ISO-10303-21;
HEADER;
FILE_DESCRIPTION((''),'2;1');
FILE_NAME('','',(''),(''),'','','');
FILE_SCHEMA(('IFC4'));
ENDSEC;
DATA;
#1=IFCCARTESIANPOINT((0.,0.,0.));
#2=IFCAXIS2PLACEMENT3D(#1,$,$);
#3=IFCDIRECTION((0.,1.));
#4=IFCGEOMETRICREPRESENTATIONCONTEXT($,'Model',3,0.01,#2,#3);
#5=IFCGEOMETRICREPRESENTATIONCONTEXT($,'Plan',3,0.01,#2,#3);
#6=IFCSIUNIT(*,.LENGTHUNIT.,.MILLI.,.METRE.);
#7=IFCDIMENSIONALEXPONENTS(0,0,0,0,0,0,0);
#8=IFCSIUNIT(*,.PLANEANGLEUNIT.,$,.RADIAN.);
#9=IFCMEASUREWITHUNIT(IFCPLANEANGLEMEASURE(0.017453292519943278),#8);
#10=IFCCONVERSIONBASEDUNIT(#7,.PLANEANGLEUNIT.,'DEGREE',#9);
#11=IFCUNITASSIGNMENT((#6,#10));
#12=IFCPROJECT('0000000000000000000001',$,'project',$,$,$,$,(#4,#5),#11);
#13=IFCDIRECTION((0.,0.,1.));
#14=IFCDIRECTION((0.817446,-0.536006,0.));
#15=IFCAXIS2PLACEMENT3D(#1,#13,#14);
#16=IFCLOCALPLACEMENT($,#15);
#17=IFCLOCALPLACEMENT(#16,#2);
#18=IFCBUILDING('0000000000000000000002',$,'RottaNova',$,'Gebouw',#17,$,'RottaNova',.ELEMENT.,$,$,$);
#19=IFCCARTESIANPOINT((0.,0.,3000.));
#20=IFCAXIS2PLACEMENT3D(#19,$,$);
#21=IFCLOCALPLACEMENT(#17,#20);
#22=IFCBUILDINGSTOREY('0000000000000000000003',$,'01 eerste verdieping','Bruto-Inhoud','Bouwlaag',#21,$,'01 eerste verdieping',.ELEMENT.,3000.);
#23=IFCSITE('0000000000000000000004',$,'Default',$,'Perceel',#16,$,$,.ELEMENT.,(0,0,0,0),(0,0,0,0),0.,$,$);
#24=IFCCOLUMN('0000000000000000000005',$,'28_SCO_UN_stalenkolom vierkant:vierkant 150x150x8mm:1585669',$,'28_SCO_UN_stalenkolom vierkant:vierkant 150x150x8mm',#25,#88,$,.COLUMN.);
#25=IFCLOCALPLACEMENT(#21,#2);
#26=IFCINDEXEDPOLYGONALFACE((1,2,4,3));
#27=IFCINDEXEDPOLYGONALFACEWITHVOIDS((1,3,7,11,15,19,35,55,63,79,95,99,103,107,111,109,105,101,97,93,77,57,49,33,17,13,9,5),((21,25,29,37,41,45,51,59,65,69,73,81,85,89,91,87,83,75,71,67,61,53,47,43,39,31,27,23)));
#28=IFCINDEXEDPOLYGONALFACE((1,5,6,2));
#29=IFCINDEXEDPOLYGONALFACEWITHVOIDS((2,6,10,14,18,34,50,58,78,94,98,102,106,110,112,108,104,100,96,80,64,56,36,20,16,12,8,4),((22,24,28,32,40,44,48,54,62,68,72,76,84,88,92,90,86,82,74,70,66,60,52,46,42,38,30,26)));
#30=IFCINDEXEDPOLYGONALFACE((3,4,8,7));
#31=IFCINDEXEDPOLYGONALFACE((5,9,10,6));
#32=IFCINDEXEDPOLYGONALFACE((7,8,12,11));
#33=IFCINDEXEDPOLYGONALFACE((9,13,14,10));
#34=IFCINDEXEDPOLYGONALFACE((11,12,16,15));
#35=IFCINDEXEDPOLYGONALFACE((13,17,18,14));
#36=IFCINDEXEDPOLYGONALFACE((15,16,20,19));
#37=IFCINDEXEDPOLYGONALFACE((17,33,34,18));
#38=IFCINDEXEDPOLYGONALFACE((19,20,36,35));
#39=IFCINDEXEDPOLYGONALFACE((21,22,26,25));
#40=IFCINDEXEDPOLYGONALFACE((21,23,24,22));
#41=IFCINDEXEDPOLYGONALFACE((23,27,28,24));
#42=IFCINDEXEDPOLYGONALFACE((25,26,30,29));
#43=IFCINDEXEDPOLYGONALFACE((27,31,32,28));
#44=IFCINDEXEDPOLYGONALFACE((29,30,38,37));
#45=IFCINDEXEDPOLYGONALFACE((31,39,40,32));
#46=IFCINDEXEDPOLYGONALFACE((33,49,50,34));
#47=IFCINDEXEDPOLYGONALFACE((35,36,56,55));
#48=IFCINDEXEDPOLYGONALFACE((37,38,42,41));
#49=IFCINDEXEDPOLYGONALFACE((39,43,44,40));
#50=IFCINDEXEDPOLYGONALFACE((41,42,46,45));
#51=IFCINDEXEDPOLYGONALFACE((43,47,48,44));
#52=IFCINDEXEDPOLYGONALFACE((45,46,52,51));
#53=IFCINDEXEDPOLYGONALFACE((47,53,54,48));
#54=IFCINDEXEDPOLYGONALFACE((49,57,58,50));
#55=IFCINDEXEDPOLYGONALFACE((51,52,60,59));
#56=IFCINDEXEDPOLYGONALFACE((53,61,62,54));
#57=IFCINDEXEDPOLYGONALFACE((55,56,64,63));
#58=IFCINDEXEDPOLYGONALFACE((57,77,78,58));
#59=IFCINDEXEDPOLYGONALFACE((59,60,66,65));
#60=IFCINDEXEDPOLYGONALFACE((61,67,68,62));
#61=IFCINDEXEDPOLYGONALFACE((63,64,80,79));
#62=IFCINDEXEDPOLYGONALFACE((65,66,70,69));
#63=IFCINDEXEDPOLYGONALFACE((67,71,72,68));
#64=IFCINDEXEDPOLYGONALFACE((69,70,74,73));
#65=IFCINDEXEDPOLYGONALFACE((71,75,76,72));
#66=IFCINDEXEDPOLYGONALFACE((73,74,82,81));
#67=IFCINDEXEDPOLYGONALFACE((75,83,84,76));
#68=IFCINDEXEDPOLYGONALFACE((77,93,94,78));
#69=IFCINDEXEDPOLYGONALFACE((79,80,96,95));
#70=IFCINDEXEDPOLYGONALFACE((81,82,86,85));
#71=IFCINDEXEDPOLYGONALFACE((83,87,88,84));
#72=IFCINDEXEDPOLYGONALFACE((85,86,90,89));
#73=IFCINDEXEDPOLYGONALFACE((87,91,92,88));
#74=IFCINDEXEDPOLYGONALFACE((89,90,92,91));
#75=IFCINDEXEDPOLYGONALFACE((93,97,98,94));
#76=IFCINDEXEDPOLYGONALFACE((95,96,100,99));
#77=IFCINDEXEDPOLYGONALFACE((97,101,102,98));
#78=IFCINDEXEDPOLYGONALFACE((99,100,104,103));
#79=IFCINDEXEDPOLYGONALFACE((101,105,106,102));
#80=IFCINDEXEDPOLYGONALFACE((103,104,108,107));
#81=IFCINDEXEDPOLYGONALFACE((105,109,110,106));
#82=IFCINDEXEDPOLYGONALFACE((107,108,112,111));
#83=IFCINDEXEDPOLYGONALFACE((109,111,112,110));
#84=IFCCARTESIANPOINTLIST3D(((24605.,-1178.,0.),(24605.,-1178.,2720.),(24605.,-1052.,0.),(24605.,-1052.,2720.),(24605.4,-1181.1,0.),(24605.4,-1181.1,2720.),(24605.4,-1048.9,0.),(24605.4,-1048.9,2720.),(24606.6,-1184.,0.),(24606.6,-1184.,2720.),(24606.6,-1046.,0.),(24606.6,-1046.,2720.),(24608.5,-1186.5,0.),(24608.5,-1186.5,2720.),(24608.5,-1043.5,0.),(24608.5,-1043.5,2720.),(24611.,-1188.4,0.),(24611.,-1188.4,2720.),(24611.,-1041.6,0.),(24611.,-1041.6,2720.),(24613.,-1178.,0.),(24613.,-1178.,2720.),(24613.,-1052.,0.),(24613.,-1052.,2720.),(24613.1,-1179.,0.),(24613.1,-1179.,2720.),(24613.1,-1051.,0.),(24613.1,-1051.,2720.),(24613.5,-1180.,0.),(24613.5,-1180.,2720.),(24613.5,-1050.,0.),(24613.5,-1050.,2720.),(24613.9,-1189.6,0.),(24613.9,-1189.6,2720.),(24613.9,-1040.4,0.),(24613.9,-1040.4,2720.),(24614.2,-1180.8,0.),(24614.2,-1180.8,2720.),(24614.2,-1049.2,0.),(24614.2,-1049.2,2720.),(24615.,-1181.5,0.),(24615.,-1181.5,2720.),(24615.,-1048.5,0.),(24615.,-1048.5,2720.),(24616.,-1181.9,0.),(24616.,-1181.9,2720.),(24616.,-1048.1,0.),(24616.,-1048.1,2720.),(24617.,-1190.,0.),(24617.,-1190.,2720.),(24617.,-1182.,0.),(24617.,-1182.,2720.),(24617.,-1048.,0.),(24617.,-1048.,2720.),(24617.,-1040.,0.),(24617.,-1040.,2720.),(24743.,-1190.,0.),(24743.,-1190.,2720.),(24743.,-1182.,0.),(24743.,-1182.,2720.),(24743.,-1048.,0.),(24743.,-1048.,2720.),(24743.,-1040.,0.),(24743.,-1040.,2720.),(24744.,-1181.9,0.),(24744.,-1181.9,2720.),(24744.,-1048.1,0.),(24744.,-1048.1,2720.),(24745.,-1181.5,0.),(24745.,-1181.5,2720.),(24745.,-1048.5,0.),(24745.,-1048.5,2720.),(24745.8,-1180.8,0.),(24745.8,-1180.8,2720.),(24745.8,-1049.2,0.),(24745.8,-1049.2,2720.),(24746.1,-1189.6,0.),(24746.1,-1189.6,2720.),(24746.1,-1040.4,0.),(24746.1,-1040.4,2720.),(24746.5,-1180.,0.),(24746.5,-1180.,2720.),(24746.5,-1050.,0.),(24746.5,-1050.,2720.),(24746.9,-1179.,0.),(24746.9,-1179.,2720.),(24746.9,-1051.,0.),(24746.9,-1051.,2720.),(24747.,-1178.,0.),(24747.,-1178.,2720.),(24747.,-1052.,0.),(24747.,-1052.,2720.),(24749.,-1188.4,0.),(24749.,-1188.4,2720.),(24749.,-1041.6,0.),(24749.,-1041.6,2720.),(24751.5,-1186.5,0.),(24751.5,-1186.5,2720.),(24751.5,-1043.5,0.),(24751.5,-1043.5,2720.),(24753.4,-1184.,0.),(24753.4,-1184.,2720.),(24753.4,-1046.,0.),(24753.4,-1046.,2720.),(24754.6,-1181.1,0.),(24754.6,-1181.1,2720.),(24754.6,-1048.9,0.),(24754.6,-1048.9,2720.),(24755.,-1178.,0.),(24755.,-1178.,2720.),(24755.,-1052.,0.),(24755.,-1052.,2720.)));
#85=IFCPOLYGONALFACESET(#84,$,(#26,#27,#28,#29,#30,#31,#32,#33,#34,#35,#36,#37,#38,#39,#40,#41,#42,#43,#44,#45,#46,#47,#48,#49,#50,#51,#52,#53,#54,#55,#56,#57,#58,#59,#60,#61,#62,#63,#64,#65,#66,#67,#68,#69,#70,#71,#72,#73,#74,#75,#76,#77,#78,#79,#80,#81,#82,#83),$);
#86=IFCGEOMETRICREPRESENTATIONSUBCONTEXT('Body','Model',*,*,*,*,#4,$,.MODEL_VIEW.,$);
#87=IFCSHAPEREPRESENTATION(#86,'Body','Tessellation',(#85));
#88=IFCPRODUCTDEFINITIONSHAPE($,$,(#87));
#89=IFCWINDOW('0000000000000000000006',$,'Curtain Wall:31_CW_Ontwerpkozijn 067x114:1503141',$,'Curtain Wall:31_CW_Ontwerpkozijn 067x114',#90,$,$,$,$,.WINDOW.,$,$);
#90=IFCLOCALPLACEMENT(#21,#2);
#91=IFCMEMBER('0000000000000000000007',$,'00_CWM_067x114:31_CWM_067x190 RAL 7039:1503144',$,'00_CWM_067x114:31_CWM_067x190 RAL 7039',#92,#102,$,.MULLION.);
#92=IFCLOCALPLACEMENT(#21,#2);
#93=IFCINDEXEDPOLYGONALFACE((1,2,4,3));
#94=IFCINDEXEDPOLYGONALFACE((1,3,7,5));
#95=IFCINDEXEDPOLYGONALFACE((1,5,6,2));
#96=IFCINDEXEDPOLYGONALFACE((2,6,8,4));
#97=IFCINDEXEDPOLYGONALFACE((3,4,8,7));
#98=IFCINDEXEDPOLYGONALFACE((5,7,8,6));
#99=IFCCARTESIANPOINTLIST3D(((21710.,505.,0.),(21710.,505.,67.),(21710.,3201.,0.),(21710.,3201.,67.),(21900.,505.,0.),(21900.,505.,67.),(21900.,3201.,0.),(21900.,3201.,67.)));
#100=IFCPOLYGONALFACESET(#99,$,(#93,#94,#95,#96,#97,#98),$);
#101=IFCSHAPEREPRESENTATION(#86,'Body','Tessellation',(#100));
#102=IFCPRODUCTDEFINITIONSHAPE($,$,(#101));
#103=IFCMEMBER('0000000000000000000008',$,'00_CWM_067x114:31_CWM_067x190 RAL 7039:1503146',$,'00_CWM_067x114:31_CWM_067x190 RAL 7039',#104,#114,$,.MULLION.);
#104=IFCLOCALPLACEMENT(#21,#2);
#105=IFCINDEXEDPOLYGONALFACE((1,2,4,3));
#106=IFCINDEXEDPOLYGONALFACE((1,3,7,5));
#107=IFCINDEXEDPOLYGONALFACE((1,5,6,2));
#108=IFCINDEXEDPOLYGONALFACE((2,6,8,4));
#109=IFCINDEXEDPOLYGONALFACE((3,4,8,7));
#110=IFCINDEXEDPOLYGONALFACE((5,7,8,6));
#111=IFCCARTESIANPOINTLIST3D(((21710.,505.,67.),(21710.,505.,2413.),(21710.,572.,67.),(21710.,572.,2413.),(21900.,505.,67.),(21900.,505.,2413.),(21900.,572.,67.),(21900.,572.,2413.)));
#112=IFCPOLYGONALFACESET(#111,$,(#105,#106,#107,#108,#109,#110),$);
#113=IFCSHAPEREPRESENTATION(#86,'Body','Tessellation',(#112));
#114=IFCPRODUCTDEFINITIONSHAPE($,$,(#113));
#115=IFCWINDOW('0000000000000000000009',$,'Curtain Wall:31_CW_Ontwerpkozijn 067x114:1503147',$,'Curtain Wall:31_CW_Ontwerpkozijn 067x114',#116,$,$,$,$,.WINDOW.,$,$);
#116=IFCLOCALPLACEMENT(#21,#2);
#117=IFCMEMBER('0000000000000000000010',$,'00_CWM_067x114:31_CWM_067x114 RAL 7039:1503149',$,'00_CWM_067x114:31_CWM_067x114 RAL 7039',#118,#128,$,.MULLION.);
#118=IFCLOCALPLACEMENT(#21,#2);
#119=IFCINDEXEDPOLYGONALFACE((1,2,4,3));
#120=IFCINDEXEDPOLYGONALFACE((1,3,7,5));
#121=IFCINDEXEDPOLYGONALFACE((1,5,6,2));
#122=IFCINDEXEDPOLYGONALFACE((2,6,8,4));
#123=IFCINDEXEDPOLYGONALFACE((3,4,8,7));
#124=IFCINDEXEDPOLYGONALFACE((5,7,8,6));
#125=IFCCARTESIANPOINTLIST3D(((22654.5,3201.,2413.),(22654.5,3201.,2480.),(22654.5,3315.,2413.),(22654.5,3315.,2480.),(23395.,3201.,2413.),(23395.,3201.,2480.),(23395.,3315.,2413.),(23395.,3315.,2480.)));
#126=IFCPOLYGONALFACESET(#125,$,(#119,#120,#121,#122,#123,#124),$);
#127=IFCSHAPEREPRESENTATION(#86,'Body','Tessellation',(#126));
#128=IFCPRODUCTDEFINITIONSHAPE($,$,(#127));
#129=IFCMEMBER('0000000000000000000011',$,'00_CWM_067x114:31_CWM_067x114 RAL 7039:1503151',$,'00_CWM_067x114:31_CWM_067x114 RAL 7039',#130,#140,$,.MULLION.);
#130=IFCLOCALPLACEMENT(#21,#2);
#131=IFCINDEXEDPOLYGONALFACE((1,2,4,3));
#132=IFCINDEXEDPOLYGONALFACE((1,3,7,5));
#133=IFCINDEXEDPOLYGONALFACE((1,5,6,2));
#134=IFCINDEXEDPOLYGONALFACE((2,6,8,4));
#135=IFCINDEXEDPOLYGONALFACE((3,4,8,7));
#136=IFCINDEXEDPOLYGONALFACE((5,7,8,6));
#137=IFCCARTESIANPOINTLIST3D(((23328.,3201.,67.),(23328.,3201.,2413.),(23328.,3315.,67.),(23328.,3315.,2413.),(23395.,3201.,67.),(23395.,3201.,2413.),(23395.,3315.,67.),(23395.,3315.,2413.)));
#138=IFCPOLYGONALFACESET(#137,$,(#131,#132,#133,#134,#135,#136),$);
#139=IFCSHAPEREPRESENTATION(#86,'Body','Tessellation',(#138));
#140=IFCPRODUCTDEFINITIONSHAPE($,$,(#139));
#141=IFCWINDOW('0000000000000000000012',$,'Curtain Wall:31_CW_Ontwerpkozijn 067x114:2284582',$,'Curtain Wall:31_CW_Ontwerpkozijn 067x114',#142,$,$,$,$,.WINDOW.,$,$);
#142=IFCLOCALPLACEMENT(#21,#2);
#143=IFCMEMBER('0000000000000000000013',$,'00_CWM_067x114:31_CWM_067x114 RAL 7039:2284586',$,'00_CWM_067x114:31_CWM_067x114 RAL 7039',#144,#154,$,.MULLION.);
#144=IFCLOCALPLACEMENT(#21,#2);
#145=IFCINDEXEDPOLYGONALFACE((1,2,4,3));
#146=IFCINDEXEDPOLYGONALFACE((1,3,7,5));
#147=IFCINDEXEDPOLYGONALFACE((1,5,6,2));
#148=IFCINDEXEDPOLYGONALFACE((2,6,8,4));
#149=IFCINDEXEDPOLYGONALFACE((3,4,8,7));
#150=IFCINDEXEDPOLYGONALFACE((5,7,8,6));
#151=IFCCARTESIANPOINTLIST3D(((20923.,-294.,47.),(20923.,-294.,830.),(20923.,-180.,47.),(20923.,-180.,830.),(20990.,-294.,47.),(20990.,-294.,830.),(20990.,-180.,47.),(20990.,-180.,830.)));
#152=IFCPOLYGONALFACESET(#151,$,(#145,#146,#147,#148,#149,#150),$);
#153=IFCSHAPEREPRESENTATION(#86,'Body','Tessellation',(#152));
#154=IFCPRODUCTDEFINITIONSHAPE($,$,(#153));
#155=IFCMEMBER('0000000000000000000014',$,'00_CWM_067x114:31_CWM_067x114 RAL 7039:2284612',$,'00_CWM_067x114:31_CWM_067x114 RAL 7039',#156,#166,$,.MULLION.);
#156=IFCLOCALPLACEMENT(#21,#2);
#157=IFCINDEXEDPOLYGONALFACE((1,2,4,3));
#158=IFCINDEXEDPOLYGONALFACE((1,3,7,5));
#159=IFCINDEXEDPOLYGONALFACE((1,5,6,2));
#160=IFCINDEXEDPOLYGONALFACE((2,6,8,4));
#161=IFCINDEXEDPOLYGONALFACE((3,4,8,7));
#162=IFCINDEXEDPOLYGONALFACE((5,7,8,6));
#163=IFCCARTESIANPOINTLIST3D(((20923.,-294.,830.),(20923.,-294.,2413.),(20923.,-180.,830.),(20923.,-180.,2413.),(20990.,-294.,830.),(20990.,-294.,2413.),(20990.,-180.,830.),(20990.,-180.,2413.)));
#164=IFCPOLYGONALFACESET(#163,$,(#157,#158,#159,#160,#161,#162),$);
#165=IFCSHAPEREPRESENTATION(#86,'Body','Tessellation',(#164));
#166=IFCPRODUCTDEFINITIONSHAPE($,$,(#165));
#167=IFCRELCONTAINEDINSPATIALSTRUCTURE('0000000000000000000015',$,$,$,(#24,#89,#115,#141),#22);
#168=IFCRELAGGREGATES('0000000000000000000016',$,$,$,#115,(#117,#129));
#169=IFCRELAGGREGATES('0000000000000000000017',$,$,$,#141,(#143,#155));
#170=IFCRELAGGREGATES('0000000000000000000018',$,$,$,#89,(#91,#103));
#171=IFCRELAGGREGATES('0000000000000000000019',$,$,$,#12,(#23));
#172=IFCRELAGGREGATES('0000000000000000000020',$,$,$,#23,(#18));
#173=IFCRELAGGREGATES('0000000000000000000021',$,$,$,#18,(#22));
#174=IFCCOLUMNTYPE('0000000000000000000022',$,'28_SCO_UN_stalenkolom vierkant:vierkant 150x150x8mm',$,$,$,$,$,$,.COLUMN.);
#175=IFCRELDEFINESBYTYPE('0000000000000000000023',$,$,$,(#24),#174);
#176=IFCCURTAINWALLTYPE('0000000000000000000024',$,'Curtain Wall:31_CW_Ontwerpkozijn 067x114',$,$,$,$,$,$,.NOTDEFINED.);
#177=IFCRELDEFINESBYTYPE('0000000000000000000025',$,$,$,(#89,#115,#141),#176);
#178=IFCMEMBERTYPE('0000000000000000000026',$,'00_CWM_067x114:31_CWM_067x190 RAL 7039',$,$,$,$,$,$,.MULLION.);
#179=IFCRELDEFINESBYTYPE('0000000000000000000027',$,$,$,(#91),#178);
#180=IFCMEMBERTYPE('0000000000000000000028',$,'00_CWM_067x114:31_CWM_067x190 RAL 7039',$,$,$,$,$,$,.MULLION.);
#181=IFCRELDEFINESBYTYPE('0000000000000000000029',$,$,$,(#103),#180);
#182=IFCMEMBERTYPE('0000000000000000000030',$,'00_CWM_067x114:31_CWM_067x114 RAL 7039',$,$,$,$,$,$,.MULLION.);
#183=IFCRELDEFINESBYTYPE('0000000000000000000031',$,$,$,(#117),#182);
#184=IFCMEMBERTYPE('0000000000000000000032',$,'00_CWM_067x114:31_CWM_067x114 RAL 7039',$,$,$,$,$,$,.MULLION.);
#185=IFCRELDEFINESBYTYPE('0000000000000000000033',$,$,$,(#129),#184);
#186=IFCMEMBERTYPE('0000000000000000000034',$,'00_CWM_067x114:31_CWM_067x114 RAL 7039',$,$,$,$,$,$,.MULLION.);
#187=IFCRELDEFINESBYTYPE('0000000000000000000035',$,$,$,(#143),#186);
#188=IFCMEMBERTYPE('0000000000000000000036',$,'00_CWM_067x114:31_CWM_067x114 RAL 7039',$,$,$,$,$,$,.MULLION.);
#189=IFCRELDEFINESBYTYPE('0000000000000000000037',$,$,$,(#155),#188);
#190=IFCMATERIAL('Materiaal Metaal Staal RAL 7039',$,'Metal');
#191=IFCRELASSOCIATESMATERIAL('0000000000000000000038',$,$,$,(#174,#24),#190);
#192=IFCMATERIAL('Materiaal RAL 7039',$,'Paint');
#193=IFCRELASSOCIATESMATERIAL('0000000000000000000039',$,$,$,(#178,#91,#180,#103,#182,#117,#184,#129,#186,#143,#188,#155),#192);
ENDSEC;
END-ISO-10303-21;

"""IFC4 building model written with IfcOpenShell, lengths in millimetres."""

from ifc_helpers import new_model, entity, si_unit, converted_unit, direction, frame, origin, place, context, subcontext, project, spatial, line, arc, indexed_curve, outline, extrude, source, transform, mapped, material, type_object, type_shapes, element, aggregate, save


model = new_model("IFC4")

# Units and contexts
model_context = context("Model", 3, precision=0.01, world=origin(), true_north=direction((0.0, 1.0)))
plan_context = context("Plan", 3, precision=0.01, world=origin(), true_north=direction((0.0, 1.0)))
body_context = subcontext(model_context, "Body", "Model", "MODEL_VIEW")
ifc_project = project(units=[si_unit("LENGTHUNIT", "METRE", prefix="MILLI"), converted_unit("PLANEANGLEUNIT", "DEGREE", entity("IfcPlaneAngleMeasure", 0.017453292519943278), si_unit("PLANEANGLEUNIT", "RADIAN"), dimensions=[0, 0, 0, 0, 0, 0, 0])], contexts=[model_context, plan_context])

# Site, building, storey
site_placement = place(None, frame((0.0, 0.0, 0.0), z_axis=(0.0, 0.0, 1.0), x_axis=(0.817446, -0.536006, 0.0)))
site = spatial("IfcSite", under=ifc_project, at=site_placement, Name="Default", ObjectType="Perceel", CompositionType="ELEMENT", RefLatitude=(0, 0, 0, 0), RefLongitude=(0, 0, 0, 0), RefElevation=0.0)
building_placement = place(site_placement, origin())
building = spatial("IfcBuilding", under=site, at=building_placement, Name="RottaNova", ObjectType="Gebouw", LongName="RottaNova", CompositionType="ELEMENT")
storey_placement = place(building_placement, frame((0.0, 0.0, 3000.0)))
storey = spatial("IfcBuildingStorey", under=building, at=storey_placement, Name="01 eerste verdieping", Description="Bruto-Inhoud", ObjectType="Bouwlaag", LongName="01 eerste verdieping", CompositionType="ELEMENT", Elevation=3000.0)

# Column
ifc_material_1 = material(Name="Materiaal Metaal Staal RAL 7039", Category="Metal")
column_type = type_object("IfcColumnType", Name="28_SCO_UN_stalenkolom vierkant:vierkant 150x150x8mm", PredefinedType="COLUMN", material=ifc_material_1)
shared_shape_1 = source(origin(), body_context, "Body", "SweptSolid", [
    extrude(outline(indexed_curve([(63.0, -75.0), (71.5, -71.5), (75.0, -63.0), (75.0, 63.0), (71.5, 71.5), (63.0, 75.0), (-63.0, 75.0), (-71.5, 71.5), (-75.0, 63.0), (-75.0, -63.0), (-71.5, -71.5), (-63.0, -75.0)], segments=[arc(1, 2, 3), line(3, 4), arc(4, 5, 6), line(6, 7), arc(7, 8, 9), line(9, 10), arc(10, 11, 12), line(12, 1)], self_intersect=False), holes=[indexed_curve([(-67.0, -63.0), (-67.0, 63.0), (-65.8, 65.8), (-63.0, 67.0), (63.0, 67.0), (65.8, 65.8), (67.0, 63.0), (67.0, -63.0), (65.8, -65.8), (63.0, -67.0), (-63.0, -67.0), (-65.8, -65.8)], segments=[line(1, 2), arc(2, 3, 4), line(4, 5), arc(5, 6, 7), line(7, 8), arc(8, 9, 10), line(10, 11), arc(11, 12, 1)], self_intersect=False)]), frame((0.0, 0.0, 3000.0)), (0.0, 0.0, 1.0), 2720.0),
])
type_shapes(column_type, [shared_shape_1])
column_placement = place(storey_placement, frame((24680.0, -1115.0, -3000.0)))
element("IfcColumn", 1, at=column_placement, inside=storey, type_object=column_type, material=ifc_material_1, Name="28_SCO_UN_stalenkolom vierkant:vierkant 150x150x8mm:1585669", ObjectType="28_SCO_UN_stalenkolom vierkant:vierkant 150x150x8mm", PredefinedType="COLUMN", context=body_context, shape_type="MappedRepresentation", body=[
    mapped(shared_shape_1, transform((0.0, 0.0, 0.0), scale=1.0)),
])

# Windows, members
curtain_wall_type = type_object("IfcCurtainWallType", Name="Curtain Wall:31_CW_Ontwerpkozijn 067x114", PredefinedType="NOTDEFINED")
window_1_placement = place(storey_placement, frame((0.0, 0.0, -3000.0)))
window_1 = element("IfcWindow", 2, at=window_1_placement, inside=storey, type_object=curtain_wall_type, Name="Curtain Wall:31_CW_Ontwerpkozijn 067x114:1503141", ObjectType="Curtain Wall:31_CW_Ontwerpkozijn 067x114", PredefinedType="WINDOW")
ifc_material_2 = material(Name="Materiaal RAL 7039", Category="Paint")
member_type_1 = type_object("IfcMemberType", Name="00_CWM_067x114:31_CWM_067x190 RAL 7039", PredefinedType="MULLION", material=ifc_material_2)
shared_shape_2 = source(origin(), body_context, "Body", "SweptSolid", [
    extrude(outline(indexed_curve([(-33.5, -95.0), (33.5, -95.0), (33.5, 95.0), (-33.5, 95.0), (-33.5, -95.0)], self_intersect=False)), frame((-33.5, 95.0, -2696.0), z_axis=(0.0, 0.0, 1.0), x_axis=(-1.0, 0.0, 0.0)), (0.0, 0.0, 1.0), 2696.0),
])
type_shapes(member_type_1, [shared_shape_2])
member_1_placement = place(window_1_placement, frame((21710.0, 505.0, 3000.0), z_axis=(0.0, -1.0, 0.0), x_axis=(0.0, 0.0, -1.0)))
member_1 = element("IfcMember", 3, at=member_1_placement, type_object=member_type_1, material=ifc_material_2, Name="00_CWM_067x114:31_CWM_067x190 RAL 7039:1503144", ObjectType="00_CWM_067x114:31_CWM_067x190 RAL 7039", PredefinedType="MULLION", context=body_context, shape_type="MappedRepresentation", body=[
    mapped(shared_shape_2, transform((0.0, 0.0, 0.0), scale=1.0)),
])
member_type_2 = type_object("IfcMemberType", Name="00_CWM_067x114:31_CWM_067x190 RAL 7039", PredefinedType="MULLION", material=ifc_material_2)
shared_shape_3 = source(origin(), body_context, "Body", "SweptSolid", [
    extrude(outline(indexed_curve([(-33.5, -95.0), (33.5, -95.0), (33.5, 95.0), (-33.5, 95.0), (-33.5, -95.0)], self_intersect=False)), frame((-33.5, 95.0, -2346.0), z_axis=(0.0, 0.0, 1.0), x_axis=(-1.0, 0.0, 0.0)), (0.0, 0.0, 1.0), 2346.0),
])
type_shapes(member_type_2, [shared_shape_3])
member_2_placement = place(window_1_placement, frame((21710.0, 505.0, 5413.0), z_axis=(0.0, 0.0, 1.0), x_axis=(0.0, -1.0, 0.0)))
member_2 = element("IfcMember", 4, at=member_2_placement, type_object=member_type_2, material=ifc_material_2, Name="00_CWM_067x114:31_CWM_067x190 RAL 7039:1503146", ObjectType="00_CWM_067x114:31_CWM_067x190 RAL 7039", PredefinedType="MULLION", context=body_context, shape_type="MappedRepresentation", body=[
    mapped(shared_shape_3, transform((0.0, 0.0, 0.0), scale=1.0)),
])
window_2_placement = place(storey_placement, frame((0.0, 0.0, -3000.0)))
window_2 = element("IfcWindow", 5, at=window_2_placement, inside=storey, type_object=curtain_wall_type, Name="Curtain Wall:31_CW_Ontwerpkozijn 067x114:1503147", ObjectType="Curtain Wall:31_CW_Ontwerpkozijn 067x114", PredefinedType="WINDOW")
member_type_3 = type_object("IfcMemberType", Name="00_CWM_067x114:31_CWM_067x114 RAL 7039", PredefinedType="MULLION", material=ifc_material_2)
shared_shape_4 = source(origin(), body_context, "Body", "SweptSolid", [
    extrude(outline(indexed_curve([(-33.5, -57.0), (33.5, -57.0), (33.5, 57.0), (-33.5, 57.0), (-33.5, -57.0)], self_intersect=False)), frame((-33.5, 57.0, -740.5), z_axis=(0.0, 0.0, 1.0), x_axis=(-1.0, 0.0, 0.0)), (0.0, 0.0, 1.0), 740.5),
])
type_shapes(member_type_3, [shared_shape_4])
member_3_placement = place(window_2_placement, frame((23395.0, 3315.0, 5480.0), z_axis=(1.0, 0.0, 0.0), x_axis=(0.0, 0.0, 1.0)))
member_3 = element("IfcMember", 6, at=member_3_placement, type_object=member_type_3, material=ifc_material_2, Name="00_CWM_067x114:31_CWM_067x114 RAL 7039:1503149", ObjectType="00_CWM_067x114:31_CWM_067x114 RAL 7039", PredefinedType="MULLION", context=body_context, shape_type="MappedRepresentation", body=[
    mapped(shared_shape_4, transform((0.0, 0.0, 0.0), scale=1.0)),
])
member_type_4 = type_object("IfcMemberType", Name="00_CWM_067x114:31_CWM_067x114 RAL 7039", PredefinedType="MULLION", material=ifc_material_2)
shared_shape_5 = source(origin(), body_context, "Body", "SweptSolid", [
    extrude(outline(indexed_curve([(-33.5, -57.0), (33.5, -57.0), (33.5, 57.0), (-33.5, 57.0), (-33.5, -57.0)], self_intersect=False)), frame((-33.5, 57.0, -2346.0), z_axis=(0.0, 0.0, 1.0), x_axis=(-1.0, 0.0, 0.0)), (0.0, 0.0, 1.0), 2346.0),
])
type_shapes(member_type_4, [shared_shape_5])
member_4_placement = place(window_2_placement, frame((23395.0, 3315.0, 3067.0), z_axis=(0.0, 0.0, -1.0), x_axis=(1.0, 0.0, 0.0)))
member_4 = element("IfcMember", 7, at=member_4_placement, type_object=member_type_4, material=ifc_material_2, Name="00_CWM_067x114:31_CWM_067x114 RAL 7039:1503151", ObjectType="00_CWM_067x114:31_CWM_067x114 RAL 7039", PredefinedType="MULLION", context=body_context, shape_type="MappedRepresentation", body=[
    mapped(shared_shape_5, transform((0.0, 0.0, 0.0), scale=1.0)),
])
window_3_placement = place(storey_placement, frame((0.0, 0.0, -3000.0)))
window_3 = element("IfcWindow", 8, at=window_3_placement, inside=storey, type_object=curtain_wall_type, Name="Curtain Wall:31_CW_Ontwerpkozijn 067x114:2284582", ObjectType="Curtain Wall:31_CW_Ontwerpkozijn 067x114", PredefinedType="WINDOW")
member_type_5 = type_object("IfcMemberType", Name="00_CWM_067x114:31_CWM_067x114 RAL 7039", PredefinedType="MULLION", material=ifc_material_2)
shared_shape_6 = source(origin(), body_context, "Body", "SweptSolid", [
    extrude(outline(indexed_curve([(-33.5, -57.0), (33.5, -57.0), (33.5, 57.0), (-33.5, 57.0), (-33.5, -57.0)], self_intersect=False)), frame((-33.5, 57.0, -783.0), z_axis=(0.0, 0.0, 1.0), x_axis=(-1.0, 0.0, 0.0)), (0.0, 0.0, 1.0), 783.0),
])
type_shapes(member_type_5, [shared_shape_6])
member_5_placement = place(window_3_placement, frame((20990.0, -180.0, 3047.0), z_axis=(0.0, 0.0, -1.0), x_axis=(1.0, 0.0, 0.0)))
member_5 = element("IfcMember", 9, at=member_5_placement, type_object=member_type_5, material=ifc_material_2, Name="00_CWM_067x114:31_CWM_067x114 RAL 7039:2284586", ObjectType="00_CWM_067x114:31_CWM_067x114 RAL 7039", PredefinedType="MULLION", context=body_context, shape_type="MappedRepresentation", body=[
    mapped(shared_shape_6, transform((0.0, 0.0, 0.0), scale=1.0)),
])
member_type_6 = type_object("IfcMemberType", Name="00_CWM_067x114:31_CWM_067x114 RAL 7039", PredefinedType="MULLION", material=ifc_material_2)
shared_shape_7 = source(origin(), body_context, "Body", "SweptSolid", [
    extrude(outline(indexed_curve([(-33.5, -57.0), (33.5, -57.0), (33.5, 57.0), (-33.5, 57.0), (-33.5, -57.0)], self_intersect=False)), frame((-33.5, 57.0, -1583.0), z_axis=(0.0, 0.0, 1.0), x_axis=(-1.0, 0.0, 0.0)), (0.0, 0.0, 1.0), 1583.0),
])
type_shapes(member_type_6, [shared_shape_7])
member_6_placement = place(window_3_placement, frame((20990.0, -180.0, 3830.0), z_axis=(0.0, 0.0, -1.0), x_axis=(1.0, 0.0, 0.0)))
member_6 = element("IfcMember", 10, at=member_6_placement, type_object=member_type_6, material=ifc_material_2, Name="00_CWM_067x114:31_CWM_067x114 RAL 7039:2284612", ObjectType="00_CWM_067x114:31_CWM_067x114 RAL 7039", PredefinedType="MULLION", context=body_context, shape_type="MappedRepresentation", body=[
    mapped(shared_shape_7, transform((0.0, 0.0, 0.0), scale=1.0)),
])

aggregate(window_2, [member_3, member_4])
aggregate(window_3, [member_5, member_6])

aggregate(window_1, [member_1, member_2])

save(model, "model.ifc")
